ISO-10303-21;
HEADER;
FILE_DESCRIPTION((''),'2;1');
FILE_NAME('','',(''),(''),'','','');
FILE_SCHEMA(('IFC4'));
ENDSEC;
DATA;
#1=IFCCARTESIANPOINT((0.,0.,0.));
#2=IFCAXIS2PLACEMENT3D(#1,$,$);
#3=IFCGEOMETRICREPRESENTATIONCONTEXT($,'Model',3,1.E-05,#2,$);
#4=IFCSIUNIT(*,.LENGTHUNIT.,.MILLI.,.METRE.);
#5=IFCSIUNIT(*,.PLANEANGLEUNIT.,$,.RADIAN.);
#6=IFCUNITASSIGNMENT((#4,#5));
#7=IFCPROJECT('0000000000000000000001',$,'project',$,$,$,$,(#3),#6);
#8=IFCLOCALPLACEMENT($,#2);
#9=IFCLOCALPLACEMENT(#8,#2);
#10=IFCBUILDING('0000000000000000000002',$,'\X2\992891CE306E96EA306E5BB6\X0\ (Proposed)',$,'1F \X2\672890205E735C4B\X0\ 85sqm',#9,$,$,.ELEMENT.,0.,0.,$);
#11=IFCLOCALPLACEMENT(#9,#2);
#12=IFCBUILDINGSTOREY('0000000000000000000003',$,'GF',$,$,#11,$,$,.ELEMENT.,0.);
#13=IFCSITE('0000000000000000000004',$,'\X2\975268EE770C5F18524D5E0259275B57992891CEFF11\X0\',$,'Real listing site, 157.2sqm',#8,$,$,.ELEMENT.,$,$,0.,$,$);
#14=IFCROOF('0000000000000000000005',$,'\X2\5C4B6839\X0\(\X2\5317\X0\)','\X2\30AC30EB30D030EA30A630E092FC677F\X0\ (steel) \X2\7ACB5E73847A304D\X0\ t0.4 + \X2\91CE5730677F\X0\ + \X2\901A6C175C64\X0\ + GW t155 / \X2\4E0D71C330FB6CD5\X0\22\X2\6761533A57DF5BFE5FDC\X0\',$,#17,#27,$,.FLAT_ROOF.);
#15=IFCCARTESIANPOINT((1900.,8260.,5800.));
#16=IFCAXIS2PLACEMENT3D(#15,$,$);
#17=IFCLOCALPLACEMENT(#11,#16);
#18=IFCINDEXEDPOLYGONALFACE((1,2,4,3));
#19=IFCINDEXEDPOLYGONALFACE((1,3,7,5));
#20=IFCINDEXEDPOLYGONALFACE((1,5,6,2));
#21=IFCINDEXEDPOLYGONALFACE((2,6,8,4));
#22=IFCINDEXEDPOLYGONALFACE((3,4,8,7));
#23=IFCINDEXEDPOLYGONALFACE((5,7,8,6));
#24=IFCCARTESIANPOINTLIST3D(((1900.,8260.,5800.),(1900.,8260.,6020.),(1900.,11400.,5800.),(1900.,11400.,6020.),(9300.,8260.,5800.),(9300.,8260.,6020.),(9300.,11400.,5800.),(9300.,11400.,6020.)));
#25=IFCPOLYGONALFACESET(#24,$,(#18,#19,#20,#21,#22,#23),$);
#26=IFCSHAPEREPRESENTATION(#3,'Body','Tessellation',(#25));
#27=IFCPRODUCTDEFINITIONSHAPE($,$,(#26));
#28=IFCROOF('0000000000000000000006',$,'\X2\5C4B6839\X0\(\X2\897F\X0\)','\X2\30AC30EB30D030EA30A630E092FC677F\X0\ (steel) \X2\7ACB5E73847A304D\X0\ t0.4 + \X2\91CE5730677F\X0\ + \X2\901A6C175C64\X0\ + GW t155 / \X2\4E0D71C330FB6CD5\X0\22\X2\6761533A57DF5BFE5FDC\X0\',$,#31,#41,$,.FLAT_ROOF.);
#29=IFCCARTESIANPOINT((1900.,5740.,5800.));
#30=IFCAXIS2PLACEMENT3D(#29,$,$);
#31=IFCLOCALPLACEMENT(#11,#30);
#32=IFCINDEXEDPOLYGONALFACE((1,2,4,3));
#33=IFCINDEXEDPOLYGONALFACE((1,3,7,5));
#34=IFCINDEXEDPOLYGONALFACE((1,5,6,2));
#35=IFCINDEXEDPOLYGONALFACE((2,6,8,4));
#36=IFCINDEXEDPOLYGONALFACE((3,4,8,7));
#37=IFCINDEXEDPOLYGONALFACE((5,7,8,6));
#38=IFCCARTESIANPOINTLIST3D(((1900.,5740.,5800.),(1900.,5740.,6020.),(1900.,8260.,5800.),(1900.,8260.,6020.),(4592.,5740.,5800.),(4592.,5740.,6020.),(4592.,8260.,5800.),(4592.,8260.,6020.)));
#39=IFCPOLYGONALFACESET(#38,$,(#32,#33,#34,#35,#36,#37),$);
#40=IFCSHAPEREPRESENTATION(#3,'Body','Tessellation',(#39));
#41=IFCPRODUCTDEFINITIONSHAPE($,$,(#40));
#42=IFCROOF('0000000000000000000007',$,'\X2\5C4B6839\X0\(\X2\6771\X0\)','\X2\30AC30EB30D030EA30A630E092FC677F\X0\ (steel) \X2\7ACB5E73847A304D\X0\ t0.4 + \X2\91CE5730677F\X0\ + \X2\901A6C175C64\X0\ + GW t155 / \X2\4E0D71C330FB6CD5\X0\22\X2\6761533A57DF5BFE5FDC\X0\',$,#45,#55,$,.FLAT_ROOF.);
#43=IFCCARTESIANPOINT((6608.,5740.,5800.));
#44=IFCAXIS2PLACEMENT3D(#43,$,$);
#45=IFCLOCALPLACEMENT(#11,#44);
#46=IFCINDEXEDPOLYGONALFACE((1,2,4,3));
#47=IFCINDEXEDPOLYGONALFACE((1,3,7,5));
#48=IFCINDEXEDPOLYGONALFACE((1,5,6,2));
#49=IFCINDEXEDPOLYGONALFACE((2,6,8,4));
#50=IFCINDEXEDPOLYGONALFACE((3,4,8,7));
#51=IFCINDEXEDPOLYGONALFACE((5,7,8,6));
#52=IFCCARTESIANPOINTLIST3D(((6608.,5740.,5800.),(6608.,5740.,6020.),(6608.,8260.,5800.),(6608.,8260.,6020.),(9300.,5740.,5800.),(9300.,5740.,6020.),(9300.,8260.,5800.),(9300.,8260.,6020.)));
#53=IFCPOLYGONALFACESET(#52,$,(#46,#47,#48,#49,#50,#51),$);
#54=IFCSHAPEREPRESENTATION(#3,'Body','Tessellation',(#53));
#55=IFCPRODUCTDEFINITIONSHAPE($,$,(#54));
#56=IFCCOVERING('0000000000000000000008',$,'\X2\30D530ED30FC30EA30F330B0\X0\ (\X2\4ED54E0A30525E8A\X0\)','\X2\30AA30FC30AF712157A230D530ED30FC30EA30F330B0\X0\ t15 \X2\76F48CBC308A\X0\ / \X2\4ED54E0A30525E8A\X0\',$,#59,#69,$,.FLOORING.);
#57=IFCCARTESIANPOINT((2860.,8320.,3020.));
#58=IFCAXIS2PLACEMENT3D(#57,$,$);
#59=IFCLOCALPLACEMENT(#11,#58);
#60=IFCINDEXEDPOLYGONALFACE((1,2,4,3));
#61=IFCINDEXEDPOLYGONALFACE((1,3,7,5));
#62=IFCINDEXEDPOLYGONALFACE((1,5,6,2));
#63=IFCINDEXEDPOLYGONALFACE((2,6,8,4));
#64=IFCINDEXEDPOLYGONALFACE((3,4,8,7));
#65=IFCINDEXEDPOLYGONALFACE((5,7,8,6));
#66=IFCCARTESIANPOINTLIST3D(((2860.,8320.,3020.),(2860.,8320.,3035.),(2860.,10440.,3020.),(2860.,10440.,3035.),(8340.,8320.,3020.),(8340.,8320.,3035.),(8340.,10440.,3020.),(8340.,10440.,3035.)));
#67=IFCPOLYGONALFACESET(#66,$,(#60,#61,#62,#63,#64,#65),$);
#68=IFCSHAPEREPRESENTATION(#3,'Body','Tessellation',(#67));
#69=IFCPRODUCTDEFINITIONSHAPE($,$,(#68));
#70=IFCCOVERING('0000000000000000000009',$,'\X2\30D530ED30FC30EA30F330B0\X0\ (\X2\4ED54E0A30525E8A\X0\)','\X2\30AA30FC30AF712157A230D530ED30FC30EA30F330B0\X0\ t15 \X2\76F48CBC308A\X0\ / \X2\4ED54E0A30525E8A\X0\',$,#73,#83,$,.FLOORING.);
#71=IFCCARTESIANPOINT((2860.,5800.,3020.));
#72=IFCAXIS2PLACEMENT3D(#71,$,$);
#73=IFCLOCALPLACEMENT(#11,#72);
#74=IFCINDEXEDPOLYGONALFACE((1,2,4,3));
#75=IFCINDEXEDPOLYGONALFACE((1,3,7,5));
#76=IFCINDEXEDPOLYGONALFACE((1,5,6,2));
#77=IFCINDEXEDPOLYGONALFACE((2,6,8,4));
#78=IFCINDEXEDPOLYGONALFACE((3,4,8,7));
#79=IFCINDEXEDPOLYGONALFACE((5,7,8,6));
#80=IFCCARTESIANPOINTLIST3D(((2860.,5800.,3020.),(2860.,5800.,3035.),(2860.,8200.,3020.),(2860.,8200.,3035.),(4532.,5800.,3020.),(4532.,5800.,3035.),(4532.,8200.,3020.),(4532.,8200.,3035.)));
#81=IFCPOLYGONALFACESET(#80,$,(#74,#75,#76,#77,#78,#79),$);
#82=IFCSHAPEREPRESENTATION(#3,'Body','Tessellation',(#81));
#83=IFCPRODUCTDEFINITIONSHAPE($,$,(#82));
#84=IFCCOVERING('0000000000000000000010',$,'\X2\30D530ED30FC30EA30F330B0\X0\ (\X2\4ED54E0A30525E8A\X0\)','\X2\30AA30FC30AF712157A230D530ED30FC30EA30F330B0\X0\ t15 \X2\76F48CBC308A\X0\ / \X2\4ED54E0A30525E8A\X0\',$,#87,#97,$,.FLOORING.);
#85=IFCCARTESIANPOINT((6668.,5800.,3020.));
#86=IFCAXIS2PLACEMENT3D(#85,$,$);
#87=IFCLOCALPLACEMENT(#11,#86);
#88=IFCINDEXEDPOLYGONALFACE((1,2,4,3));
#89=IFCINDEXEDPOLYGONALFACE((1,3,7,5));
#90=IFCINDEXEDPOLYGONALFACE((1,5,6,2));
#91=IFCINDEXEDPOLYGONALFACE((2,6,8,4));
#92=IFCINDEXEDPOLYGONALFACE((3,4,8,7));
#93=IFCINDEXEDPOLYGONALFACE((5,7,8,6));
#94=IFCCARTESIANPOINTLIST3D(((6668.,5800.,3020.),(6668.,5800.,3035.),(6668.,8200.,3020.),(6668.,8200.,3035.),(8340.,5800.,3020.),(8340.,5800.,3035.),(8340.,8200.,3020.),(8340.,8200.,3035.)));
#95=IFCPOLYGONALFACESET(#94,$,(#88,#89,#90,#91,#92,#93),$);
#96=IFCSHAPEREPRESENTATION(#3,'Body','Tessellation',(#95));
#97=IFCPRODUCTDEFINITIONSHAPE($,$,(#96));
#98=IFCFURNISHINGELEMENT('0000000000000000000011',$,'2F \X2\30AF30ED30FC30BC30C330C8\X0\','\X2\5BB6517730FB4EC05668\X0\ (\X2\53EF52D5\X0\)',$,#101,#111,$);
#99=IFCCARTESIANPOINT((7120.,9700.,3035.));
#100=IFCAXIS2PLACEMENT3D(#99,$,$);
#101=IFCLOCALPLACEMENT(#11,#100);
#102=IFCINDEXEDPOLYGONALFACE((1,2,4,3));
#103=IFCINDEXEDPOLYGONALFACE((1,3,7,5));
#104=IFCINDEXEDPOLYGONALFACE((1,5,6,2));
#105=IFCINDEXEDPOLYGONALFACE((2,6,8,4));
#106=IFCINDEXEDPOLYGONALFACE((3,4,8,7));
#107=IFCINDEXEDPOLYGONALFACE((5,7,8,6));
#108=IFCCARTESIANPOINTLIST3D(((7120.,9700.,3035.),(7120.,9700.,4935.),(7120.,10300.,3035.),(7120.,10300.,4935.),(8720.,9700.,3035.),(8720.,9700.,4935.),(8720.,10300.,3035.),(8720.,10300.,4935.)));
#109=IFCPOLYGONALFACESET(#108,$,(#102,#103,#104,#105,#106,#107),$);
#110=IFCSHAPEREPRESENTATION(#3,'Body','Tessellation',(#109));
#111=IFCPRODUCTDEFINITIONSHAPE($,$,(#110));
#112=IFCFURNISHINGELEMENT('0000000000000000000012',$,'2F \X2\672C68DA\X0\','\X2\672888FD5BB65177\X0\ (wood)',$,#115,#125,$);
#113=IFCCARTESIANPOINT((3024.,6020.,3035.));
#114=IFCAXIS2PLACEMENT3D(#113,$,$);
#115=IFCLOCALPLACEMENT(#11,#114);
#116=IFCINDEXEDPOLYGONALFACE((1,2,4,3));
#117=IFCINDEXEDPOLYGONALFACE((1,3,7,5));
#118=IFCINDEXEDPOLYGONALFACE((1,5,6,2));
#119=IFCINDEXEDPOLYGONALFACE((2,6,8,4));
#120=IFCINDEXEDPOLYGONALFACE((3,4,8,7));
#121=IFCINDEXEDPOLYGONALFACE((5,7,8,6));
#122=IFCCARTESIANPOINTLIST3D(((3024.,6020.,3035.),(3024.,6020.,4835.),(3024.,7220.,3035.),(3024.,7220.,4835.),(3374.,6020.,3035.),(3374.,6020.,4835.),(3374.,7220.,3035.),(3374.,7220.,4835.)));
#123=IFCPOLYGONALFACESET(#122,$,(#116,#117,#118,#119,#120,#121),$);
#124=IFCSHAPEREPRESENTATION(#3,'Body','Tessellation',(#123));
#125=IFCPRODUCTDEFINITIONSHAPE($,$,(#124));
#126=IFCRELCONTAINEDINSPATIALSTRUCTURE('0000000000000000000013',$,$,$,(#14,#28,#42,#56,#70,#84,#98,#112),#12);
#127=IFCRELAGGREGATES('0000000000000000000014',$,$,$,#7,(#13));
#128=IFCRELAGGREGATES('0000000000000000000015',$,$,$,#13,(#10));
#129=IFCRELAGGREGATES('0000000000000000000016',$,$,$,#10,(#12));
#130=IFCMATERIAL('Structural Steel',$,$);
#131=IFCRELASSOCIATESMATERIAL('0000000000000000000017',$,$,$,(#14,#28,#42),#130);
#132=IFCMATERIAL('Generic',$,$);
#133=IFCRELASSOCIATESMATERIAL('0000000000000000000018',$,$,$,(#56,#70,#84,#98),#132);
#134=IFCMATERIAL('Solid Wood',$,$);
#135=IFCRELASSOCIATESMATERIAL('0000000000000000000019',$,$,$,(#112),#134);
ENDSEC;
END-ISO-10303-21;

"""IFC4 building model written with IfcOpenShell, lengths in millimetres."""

from ifc_helpers import new_model, si_unit, frame, frame_2d, origin, place, context, project, spatial, rectangle, extrude, material, element, save


model = new_model("IFC4")

# Units and contexts
model_context = context("Model", 3, precision=1e-05, world=origin())
ifc_project = project(units=[si_unit("LENGTHUNIT", "METRE", prefix="MILLI"), si_unit("PLANEANGLEUNIT", "RADIAN")], contexts=[model_context])

# Site, building, storey
site_placement = place(None, origin())
site = spatial("IfcSite", under=ifc_project, at=site_placement, Name="青森県弘前市大字館野１", ObjectType="Real listing site, 157.2sqm", CompositionType="ELEMENT", RefElevation=0.0)
building_placement = place(site_placement, origin())
building = spatial("IfcBuilding", under=site, at=building_placement, Name="館野の雪の家 (Proposed)", ObjectType="1F 木造平屋 85sqm", CompositionType="ELEMENT", ElevationOfRefHeight=0.0, ElevationOfTerrain=0.0)
storey_placement = place(building_placement, origin())
storey = spatial("IfcBuildingStorey", under=building, at=storey_placement, Name="GF", CompositionType="ELEMENT", Elevation=0.0)

# Shared definitions
ifc_material_1 = material(Name="Solid Wood")

# Shared definitions
ifc_material_2 = material(Name="Generic")

# Roofs
ifc_material_3 = material(Name="Structural Steel")
for number, where, name in (
    (1, (1900.0, 8260.0, 5800.0), "屋根(北)"),
):
    element("IfcRoof", number, at=place(storey_placement, frame(where)), inside=storey, material=ifc_material_3, Name=name, Description="ガルバリウム鋼板 (steel) 立平葺き t0.4 + 野地板 + 通気層 + GW t155 / 不燃・法22条区域対応", PredefinedType="FLAT_ROOF", context=model_context, shape_type="SweptSolid", body=[
        extrude(rectangle(XDim=7400.0, YDim=3140.0, at=frame_2d((3700.0, 1570.0))), frame((1900.0, 8260.0, 5800.0)), (0.0, 0.0, 1.0), 220.0),
    ])
roof_1_placement = place(storey_placement, frame((1900.0, 5740.0, 5800.0)))
element("IfcRoof", 2, at=roof_1_placement, inside=storey, material=ifc_material_3, Name="屋根(西)", Description="ガルバリウム鋼板 (steel) 立平葺き t0.4 + 野地板 + 通気層 + GW t155 / 不燃・法22条区域対応", PredefinedType="FLAT_ROOF", context=model_context, shape_type="SweptSolid", body=[
    extrude(rectangle(XDim=2692.0, YDim=2520.0, at=frame_2d((1346.0, 1260.0))), frame((1900.0, 5740.0, 5800.0)), (0.0, 0.0, 1.0), 220.0),
])
roof_2_placement = place(storey_placement, frame((6608.0, 5740.0, 5800.0)))
element("IfcRoof", 3, at=roof_2_placement, inside=storey, material=ifc_material_3, Name="屋根(東)", Description="ガルバリウム鋼板 (steel) 立平葺き t0.4 + 野地板 + 通気層 + GW t155 / 不燃・法22条区域対応", PredefinedType="FLAT_ROOF", context=model_context, shape_type="SweptSolid", body=[
    extrude(rectangle(XDim=2692.0, YDim=2520.0, at=frame_2d((1346.0, 1260.0))), frame((6608.0, 5740.0, 5800.0)), (0.0, 0.0, 1.0), 220.0),
])

# Coverings
covering_1_placement = place(storey_placement, frame((2860.0, 8320.0, 3020.0)))
element("IfcCovering", 4, at=covering_1_placement, inside=storey, material=ifc_material_2, Name="フローリング (仕上げ床)", Description="オーク無垢フローリング t15 直貼り / 仕上げ床", PredefinedType="FLOORING", context=model_context, shape_type="SweptSolid", body=[
    extrude(rectangle(XDim=5480.0, YDim=2120.0, at=frame_2d((2740.0, 1060.0))), frame((2860.0, 8320.0, 3020.0)), (0.0, 0.0, 1.0), 15.0),
])
covering_2_placement = place(storey_placement, frame((2860.0, 5800.0, 3020.0)))
element("IfcCovering", 5, at=covering_2_placement, inside=storey, material=ifc_material_2, Name="フローリング (仕上げ床)", Description="オーク無垢フローリング t15 直貼り / 仕上げ床", PredefinedType="FLOORING", context=model_context, shape_type="SweptSolid", body=[
    extrude(rectangle(XDim=1672.0, YDim=2400.0, at=frame_2d((836.0, 1200.0))), frame((2860.0, 5800.0, 3020.0)), (0.0, 0.0, 1.0), 15.0),
])
covering_3_placement = place(storey_placement, frame((6668.0, 5800.0, 3020.0)))
element("IfcCovering", 6, at=covering_3_placement, inside=storey, material=ifc_material_2, Name="フローリング (仕上げ床)", Description="オーク無垢フローリング t15 直貼り / 仕上げ床", PredefinedType="FLOORING", context=model_context, shape_type="SweptSolid", body=[
    extrude(rectangle(XDim=1672.0, YDim=2400.0, at=frame_2d((836.0, 1200.0))), frame((6668.0, 5800.0, 3020.0)), (0.0, 0.0, 1.0), 15.0),
])

# Furnishing elements
furnishing_1_placement = place(storey_placement, frame((7120.0, 9700.0, 3035.0)))
element("IfcFurnishingElement", 7, at=furnishing_1_placement, inside=storey, material=ifc_material_2, Name="2F クローゼット", Description="家具・什器 (可動)", context=model_context, shape_type="SweptSolid", body=[
    extrude(rectangle(XDim=1600.0, YDim=600.0, at=frame_2d((800.0, 300.0))), frame((7120.0, 9700.0, 3035.0)), (0.0, 0.0, 1.0), 1900.0),
])
furnishing_2_placement = place(storey_placement, frame((3024.0, 6020.0, 3035.0)))
element("IfcFurnishingElement", 8, at=furnishing_2_placement, inside=storey, material=ifc_material_1, Name="2F 本棚", Description="木製家具 (wood)", context=model_context, shape_type="SweptSolid", body=[
    extrude(rectangle(XDim=350.0, YDim=1200.0, at=frame_2d((175.0, 600.0))), frame((3024.0, 6020.0, 3035.0)), (0.0, 0.0, 1.0), 1800.0),
])

save(model, "model.ifc")
